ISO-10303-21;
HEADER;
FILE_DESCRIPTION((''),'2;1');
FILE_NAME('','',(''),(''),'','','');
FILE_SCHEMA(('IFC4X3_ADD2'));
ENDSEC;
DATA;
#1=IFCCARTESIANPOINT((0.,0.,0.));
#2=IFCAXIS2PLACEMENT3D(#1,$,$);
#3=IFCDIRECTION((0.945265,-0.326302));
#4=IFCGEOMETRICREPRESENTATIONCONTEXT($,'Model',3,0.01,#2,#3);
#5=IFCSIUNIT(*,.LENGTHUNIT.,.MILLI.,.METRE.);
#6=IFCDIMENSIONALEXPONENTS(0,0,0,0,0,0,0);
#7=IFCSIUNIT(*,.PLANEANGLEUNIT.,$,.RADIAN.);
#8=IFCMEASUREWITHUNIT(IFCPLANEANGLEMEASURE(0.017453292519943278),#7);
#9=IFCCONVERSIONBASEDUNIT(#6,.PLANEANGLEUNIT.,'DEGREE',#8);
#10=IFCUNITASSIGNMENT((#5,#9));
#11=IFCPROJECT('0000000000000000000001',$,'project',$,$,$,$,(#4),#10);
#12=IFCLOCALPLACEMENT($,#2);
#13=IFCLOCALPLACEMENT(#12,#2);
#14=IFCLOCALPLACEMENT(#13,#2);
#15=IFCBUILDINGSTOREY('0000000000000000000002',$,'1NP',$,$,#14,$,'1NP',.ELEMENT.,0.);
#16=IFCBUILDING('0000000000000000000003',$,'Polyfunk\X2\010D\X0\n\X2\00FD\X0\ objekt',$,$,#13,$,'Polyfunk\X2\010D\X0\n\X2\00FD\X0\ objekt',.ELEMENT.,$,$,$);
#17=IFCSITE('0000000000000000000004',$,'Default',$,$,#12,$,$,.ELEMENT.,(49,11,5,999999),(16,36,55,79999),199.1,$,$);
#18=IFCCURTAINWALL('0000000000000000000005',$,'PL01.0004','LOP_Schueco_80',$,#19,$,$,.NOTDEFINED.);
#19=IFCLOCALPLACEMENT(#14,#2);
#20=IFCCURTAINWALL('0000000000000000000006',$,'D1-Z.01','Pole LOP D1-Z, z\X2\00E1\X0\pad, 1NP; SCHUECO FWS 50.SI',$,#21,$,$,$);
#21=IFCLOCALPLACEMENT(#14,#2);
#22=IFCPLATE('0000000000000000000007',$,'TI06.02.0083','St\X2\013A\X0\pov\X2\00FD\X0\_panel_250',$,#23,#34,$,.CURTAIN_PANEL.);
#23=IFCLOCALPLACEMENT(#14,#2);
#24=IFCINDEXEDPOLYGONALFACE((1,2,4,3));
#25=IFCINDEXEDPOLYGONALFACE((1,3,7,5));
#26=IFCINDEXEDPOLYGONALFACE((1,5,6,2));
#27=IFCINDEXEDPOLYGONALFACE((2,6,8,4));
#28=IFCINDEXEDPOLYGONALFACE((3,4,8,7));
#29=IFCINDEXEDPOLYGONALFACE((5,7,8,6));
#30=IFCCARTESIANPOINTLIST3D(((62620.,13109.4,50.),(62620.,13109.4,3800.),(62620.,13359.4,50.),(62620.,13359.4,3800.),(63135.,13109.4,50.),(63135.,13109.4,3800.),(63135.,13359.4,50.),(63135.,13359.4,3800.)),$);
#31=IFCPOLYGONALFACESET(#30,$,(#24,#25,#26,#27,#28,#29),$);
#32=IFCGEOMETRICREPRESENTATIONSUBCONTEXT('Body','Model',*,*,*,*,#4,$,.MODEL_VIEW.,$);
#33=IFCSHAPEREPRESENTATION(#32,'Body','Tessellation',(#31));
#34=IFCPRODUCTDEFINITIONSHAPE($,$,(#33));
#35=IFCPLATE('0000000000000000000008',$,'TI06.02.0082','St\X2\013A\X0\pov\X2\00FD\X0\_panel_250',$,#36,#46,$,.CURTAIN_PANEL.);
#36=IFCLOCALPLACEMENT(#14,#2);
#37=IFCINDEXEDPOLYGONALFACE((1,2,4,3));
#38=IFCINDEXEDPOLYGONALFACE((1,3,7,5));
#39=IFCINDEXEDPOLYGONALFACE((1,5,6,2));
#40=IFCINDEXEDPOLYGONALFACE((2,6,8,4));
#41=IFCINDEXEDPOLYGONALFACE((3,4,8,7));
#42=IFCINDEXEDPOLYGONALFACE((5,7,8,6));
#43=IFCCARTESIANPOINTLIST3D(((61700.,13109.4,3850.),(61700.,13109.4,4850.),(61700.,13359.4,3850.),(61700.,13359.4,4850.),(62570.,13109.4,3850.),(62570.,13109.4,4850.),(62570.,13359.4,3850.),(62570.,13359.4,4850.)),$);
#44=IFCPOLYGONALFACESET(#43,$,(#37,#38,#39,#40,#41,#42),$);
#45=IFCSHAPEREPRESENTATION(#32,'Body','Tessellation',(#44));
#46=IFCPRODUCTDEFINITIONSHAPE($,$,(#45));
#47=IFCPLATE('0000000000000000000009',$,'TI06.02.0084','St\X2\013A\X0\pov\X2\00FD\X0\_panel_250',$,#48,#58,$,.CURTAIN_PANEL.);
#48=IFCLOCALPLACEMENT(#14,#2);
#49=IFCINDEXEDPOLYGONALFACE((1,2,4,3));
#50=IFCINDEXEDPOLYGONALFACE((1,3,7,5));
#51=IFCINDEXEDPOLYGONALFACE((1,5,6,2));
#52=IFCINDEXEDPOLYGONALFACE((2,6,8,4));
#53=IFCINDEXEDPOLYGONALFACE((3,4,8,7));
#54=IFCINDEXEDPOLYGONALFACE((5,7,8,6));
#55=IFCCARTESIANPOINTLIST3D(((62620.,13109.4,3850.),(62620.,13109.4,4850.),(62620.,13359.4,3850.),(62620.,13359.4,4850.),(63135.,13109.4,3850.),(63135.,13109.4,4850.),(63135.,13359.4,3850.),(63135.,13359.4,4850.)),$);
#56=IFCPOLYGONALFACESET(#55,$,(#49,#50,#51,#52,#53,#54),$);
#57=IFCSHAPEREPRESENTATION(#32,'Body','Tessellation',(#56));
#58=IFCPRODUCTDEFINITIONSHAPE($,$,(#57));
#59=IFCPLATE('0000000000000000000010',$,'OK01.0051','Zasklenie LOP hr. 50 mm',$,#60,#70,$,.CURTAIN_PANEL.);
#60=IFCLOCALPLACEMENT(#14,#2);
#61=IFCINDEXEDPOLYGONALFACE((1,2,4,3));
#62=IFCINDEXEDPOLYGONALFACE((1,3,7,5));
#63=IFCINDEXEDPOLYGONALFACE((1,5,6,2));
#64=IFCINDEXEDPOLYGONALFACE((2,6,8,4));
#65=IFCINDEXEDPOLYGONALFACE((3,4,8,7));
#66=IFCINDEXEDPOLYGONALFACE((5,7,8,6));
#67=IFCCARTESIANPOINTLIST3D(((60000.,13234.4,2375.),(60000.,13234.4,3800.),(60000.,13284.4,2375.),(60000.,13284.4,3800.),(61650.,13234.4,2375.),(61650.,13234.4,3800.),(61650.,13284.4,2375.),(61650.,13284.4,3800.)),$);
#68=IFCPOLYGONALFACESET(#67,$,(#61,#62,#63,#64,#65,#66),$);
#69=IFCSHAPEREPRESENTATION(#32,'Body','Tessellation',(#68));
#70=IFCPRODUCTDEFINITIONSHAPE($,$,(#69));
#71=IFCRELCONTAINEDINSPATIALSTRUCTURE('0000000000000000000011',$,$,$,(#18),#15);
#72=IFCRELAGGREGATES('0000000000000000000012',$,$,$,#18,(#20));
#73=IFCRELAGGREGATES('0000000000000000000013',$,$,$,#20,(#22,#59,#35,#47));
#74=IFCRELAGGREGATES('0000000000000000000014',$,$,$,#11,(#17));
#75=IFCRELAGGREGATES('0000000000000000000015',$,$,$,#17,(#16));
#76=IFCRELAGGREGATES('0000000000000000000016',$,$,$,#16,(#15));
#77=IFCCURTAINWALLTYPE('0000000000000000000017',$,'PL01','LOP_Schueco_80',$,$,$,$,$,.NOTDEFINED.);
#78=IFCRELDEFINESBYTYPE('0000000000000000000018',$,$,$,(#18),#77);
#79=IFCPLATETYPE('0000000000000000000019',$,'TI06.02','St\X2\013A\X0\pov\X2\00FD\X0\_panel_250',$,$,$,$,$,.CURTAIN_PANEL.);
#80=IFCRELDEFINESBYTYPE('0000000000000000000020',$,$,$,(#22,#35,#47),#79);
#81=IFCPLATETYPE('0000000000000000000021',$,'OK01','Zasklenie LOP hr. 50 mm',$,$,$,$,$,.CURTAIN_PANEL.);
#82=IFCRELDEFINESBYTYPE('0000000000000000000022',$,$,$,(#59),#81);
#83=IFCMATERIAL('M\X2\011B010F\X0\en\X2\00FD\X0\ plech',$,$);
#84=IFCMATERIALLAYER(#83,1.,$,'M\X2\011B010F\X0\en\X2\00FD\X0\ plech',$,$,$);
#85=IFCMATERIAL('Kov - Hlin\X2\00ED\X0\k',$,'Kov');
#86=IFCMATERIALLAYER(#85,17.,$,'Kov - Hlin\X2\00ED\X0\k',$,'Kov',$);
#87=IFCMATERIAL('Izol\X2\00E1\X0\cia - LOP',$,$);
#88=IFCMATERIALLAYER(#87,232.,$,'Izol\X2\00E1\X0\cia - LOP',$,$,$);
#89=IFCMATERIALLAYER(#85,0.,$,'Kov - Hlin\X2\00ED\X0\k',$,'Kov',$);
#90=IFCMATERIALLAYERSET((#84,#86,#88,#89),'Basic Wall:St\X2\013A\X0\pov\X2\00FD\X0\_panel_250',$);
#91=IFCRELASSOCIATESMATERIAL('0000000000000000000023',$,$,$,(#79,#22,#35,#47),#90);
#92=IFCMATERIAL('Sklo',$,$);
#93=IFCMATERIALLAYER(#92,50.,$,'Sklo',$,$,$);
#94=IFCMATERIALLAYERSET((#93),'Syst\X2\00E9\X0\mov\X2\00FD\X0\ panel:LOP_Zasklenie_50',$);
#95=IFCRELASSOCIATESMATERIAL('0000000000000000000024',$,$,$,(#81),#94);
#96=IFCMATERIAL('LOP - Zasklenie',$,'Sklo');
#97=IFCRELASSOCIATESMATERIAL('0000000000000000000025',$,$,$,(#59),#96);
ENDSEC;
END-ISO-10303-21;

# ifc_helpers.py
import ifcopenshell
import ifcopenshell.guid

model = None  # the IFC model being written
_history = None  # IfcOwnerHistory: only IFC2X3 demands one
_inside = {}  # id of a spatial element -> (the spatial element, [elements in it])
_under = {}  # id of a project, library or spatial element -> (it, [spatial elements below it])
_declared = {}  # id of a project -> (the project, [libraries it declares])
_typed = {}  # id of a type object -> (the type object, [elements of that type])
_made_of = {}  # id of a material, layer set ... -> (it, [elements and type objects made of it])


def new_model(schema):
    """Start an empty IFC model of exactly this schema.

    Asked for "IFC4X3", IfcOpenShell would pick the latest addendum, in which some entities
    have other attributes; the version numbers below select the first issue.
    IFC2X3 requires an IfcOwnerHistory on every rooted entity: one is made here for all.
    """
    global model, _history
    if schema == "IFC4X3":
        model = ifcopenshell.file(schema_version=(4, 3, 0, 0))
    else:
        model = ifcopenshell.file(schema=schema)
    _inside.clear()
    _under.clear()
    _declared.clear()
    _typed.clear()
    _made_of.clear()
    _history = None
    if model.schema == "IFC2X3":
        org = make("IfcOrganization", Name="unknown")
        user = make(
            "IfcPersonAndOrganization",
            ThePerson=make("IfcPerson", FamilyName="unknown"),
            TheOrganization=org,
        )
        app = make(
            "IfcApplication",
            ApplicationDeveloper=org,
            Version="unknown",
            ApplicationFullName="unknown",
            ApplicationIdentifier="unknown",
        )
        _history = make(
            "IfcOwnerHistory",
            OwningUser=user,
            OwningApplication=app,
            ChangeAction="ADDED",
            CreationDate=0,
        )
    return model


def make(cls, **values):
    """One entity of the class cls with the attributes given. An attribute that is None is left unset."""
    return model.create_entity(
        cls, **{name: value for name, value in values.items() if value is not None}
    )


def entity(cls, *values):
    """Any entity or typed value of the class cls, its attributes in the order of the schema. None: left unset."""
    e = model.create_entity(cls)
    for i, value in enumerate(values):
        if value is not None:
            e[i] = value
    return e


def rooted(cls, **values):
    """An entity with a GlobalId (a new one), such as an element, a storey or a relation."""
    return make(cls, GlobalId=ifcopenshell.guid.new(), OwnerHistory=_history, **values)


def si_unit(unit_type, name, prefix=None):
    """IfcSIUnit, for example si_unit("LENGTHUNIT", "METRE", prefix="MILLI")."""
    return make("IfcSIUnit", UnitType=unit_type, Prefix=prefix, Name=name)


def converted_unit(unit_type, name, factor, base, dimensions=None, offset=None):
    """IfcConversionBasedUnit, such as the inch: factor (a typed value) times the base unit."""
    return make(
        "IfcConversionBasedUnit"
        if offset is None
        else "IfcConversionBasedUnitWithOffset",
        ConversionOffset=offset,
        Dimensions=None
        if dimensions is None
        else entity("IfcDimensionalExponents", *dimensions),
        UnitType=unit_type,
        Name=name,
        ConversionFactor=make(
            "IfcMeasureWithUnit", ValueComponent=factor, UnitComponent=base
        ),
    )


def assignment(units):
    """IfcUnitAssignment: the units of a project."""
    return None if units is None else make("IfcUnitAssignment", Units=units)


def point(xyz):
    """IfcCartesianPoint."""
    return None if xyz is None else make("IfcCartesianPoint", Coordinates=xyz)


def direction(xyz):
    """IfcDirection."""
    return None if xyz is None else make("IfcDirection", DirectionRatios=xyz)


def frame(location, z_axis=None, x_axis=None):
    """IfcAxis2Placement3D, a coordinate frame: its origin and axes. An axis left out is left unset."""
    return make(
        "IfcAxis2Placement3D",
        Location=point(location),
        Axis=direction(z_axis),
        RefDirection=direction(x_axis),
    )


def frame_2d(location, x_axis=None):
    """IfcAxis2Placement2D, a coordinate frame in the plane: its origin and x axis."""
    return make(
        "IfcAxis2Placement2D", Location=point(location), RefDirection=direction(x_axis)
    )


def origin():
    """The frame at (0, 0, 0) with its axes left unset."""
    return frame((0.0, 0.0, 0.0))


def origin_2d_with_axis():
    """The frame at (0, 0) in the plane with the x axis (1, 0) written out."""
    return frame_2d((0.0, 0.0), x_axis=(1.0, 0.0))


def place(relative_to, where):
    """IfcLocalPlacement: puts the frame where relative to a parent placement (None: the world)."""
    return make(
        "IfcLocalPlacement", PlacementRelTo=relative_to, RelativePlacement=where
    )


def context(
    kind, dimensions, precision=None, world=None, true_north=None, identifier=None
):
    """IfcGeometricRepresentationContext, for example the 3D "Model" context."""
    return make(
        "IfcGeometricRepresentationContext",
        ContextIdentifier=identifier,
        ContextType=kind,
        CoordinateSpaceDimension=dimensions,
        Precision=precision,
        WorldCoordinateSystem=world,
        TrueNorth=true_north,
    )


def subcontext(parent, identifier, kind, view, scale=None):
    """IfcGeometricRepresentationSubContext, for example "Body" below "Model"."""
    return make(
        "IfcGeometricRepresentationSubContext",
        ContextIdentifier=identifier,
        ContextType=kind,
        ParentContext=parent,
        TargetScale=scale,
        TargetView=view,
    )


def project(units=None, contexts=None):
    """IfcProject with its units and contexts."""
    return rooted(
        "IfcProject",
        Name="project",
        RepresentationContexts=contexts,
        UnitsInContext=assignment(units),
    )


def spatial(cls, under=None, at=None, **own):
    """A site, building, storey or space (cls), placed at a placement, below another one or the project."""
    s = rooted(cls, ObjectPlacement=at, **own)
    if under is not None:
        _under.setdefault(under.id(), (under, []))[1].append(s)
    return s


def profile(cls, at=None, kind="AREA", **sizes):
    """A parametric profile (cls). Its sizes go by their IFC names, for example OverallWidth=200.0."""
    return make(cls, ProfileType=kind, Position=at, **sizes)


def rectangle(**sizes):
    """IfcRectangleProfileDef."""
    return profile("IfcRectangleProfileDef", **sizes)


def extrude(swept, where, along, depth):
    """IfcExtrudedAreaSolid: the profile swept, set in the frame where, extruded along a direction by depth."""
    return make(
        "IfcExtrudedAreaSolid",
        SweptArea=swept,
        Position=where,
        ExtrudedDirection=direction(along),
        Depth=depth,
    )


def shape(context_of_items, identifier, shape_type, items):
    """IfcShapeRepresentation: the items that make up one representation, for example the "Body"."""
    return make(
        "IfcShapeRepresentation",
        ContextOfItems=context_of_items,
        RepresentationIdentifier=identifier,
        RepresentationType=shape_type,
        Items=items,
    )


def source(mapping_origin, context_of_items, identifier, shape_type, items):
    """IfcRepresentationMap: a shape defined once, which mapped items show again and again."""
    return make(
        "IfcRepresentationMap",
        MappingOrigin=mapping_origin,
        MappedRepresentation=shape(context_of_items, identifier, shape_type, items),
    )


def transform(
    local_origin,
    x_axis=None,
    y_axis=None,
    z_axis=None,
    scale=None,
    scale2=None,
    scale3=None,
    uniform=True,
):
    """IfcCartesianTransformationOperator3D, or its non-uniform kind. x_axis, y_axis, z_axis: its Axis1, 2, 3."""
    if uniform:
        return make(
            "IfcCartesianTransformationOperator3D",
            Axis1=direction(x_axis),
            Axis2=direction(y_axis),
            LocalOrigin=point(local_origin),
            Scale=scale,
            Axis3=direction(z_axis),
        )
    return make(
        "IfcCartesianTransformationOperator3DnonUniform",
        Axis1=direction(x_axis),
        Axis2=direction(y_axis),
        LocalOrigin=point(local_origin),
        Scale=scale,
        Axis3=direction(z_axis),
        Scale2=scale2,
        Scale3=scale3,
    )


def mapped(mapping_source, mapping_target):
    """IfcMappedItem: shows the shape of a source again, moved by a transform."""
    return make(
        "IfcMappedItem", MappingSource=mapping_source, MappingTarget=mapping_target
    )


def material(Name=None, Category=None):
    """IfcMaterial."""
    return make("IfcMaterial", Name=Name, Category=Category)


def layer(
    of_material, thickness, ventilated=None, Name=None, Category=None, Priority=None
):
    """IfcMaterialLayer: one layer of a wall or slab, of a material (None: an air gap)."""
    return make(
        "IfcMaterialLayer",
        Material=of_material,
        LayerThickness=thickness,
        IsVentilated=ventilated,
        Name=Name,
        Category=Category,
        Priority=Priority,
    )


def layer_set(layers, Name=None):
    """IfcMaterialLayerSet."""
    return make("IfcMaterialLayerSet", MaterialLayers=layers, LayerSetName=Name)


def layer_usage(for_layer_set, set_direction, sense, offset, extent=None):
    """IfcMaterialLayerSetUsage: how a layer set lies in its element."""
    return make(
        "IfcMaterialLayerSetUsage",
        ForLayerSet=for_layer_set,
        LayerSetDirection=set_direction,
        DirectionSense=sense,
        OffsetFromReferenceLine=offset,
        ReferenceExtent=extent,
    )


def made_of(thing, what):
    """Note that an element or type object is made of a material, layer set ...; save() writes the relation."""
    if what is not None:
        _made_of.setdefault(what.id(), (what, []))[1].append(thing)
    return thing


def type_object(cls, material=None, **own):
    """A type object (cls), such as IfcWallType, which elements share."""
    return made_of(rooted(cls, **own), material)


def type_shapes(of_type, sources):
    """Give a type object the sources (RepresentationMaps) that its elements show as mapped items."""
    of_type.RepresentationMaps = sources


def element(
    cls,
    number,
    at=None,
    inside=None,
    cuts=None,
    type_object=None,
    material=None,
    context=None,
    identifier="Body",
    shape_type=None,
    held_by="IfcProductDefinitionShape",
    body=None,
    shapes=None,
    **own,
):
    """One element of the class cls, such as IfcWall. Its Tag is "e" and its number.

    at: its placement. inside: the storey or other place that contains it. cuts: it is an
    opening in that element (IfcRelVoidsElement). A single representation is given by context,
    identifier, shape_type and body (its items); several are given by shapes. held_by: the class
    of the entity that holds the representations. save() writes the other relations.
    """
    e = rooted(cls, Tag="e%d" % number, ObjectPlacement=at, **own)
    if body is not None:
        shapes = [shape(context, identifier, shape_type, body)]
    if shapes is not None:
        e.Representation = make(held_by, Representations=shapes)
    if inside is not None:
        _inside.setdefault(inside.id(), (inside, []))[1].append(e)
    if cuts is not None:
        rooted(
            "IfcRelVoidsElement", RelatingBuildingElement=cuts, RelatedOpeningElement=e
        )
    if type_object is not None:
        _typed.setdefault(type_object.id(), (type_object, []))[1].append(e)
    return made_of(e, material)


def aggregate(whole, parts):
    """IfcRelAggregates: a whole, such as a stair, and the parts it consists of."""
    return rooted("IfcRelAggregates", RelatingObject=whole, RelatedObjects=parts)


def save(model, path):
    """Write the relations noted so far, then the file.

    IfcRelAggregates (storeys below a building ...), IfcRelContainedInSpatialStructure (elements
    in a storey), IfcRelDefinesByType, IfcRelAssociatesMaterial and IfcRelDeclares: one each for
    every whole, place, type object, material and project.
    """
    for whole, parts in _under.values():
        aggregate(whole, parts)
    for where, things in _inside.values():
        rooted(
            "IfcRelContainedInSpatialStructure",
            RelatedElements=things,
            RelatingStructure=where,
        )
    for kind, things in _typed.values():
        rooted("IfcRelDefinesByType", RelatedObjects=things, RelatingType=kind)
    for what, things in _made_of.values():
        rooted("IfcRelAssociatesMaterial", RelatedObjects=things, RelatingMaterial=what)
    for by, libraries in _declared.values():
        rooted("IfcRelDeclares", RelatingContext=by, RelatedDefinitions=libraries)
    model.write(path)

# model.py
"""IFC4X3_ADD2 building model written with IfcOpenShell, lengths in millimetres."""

from ifc_helpers import new_model, entity, si_unit, converted_unit, direction, frame, frame_2d, origin, origin_2d_with_axis, place, context, subcontext, project, spatial, rectangle, extrude, source, transform, mapped, material, layer, layer_set, layer_usage, type_object, type_shapes, element, aggregate, save


model = new_model("IFC4X3_ADD2")

# Units and contexts
model_context = context("Model", 3, precision=0.01, world=origin(), true_north=direction((0.945265, -0.326302)))
body_context = subcontext(model_context, "Body", "Model", "MODEL_VIEW")
ifc_project = project(units=[si_unit("LENGTHUNIT", "METRE", prefix="MILLI"), converted_unit("PLANEANGLEUNIT", "DEGREE", entity("IfcPlaneAngleMeasure", 0.017453292519943278), si_unit("PLANEANGLEUNIT", "RADIAN"), dimensions=[0, 0, 0, 0, 0, 0, 0])], contexts=[model_context])

# Site, building, storey
site_placement = place(None, origin())
site = spatial("IfcSite", under=ifc_project, at=site_placement, Name="Default", CompositionType="ELEMENT", RefLatitude=(49, 11, 5, 999999), RefLongitude=(16, 36, 55, 79999), RefElevation=199.1)
building_placement = place(site_placement, origin())
building = spatial("IfcBuilding", under=site, at=building_placement, Name="Polyfunkčný objekt", LongName="Polyfunkčný objekt", CompositionType="ELEMENT")
storey_placement = place(building_placement, origin())
storey = spatial("IfcBuildingStorey", under=building, at=storey_placement, Name="1NP", LongName="1NP", CompositionType="ELEMENT", Elevation=0.0)

# Curtain walls, plates
curtain_wall_type = type_object("IfcCurtainWallType", Name="PL01", Description="LOP_Schueco_80", PredefinedType="NOTDEFINED")
curtain_wall_1_placement = place(storey_placement, origin())
curtain_wall_1 = element("IfcCurtainWall", 1, at=curtain_wall_1_placement, inside=storey, type_object=curtain_wall_type, Name="PL01.0004", Description="LOP_Schueco_80", PredefinedType="NOTDEFINED")
curtain_wall_2 = element("IfcCurtainWall", 2, Name="D1-Z.01", Description="Pole LOP D1-Z, západ, 1NP; SCHUECO FWS 50.SI")
aggregate(curtain_wall_1, [curtain_wall_2])
ifc_material_1 = material(Name="Měďený plech")
ifc_layer_1 = layer(ifc_material_1, 1.0, Name="Měďený plech")
ifc_material_2 = material(Name="Kov - Hliník", Category="Kov")
ifc_layer_2 = layer(ifc_material_2, 17.0, Name="Kov - Hliník", Category="Kov")
ifc_material_3 = material(Name="Izolácia - LOP")
ifc_layer_3 = layer(ifc_material_3, 232.0, Name="Izolácia - LOP")
ifc_layer_4 = layer(ifc_material_2, 0.0, Name="Kov - Hliník", Category="Kov")
ifc_layer_set_1 = layer_set([ifc_layer_1, ifc_layer_2, ifc_layer_3, ifc_layer_4], Name="Basic Wall:Stĺpový_panel_250")
ifc_layer_usage_1 = layer_usage(ifc_layer_set_1, "AXIS2", "NEGATIVE", 125.0)
plate_type_1 = type_object("IfcPlateType", Name="TI06.02", Description="Stĺpový_panel_250", PredefinedType="CURTAIN_PANEL", material=ifc_layer_set_1)
plate_1_placement = place(storey_placement, frame((62620.0, 13234.4, 50.0)))
plate_1 = element("IfcPlate", 3, at=plate_1_placement, type_object=plate_type_1, material=ifc_layer_usage_1, Name="TI06.02.0083", Description="Stĺpový_panel_250", PredefinedType="CURTAIN_PANEL", context=body_context, shape_type="SweptSolid", body=[
    extrude(rectangle(XDim=250.0, YDim=515.0, at=frame_2d((0.0, 0.0), x_axis=(1.0, 0.0))), frame((257.5, 0.0, 0.0), z_axis=(0.0, 0.0, 1.0), x_axis=(0.0, 1.0, 0.0)), (0.0, 0.0, 1.0), 3750.0),
])
ifc_layer_usage_2 = layer_usage(ifc_layer_set_1, "AXIS2", "NEGATIVE", 125.0)
plate_2_placement = place(storey_placement, frame((61700.0, 13234.4, 3850.0)))
plate_2 = element("IfcPlate", 4, at=plate_2_placement, type_object=plate_type_1, material=ifc_layer_usage_2, Name="TI06.02.0082", Description="Stĺpový_panel_250", PredefinedType="CURTAIN_PANEL", context=body_context, shape_type="SweptSolid", body=[
    extrude(rectangle(XDim=250.0, YDim=870.0, at=frame_2d((0.0, 0.0), x_axis=(1.0, 0.0))), frame((435.0, 0.0, 0.0), z_axis=(0.0, 0.0, 1.0), x_axis=(0.0, 1.0, 0.0)), (0.0, 0.0, 1.0), 1000.0),
])
ifc_layer_usage_3 = layer_usage(ifc_layer_set_1, "AXIS2", "NEGATIVE", 125.0)
plate_3_placement = place(storey_placement, frame((62620.0, 13234.4, 3850.0)))
plate_3 = element("IfcPlate", 5, at=plate_3_placement, type_object=plate_type_1, material=ifc_layer_usage_3, Name="TI06.02.0084", Description="Stĺpový_panel_250", PredefinedType="CURTAIN_PANEL", context=body_context, shape_type="SweptSolid", body=[
    extrude(rectangle(XDim=250.0, YDim=515.0, at=frame_2d((0.0, 0.0), x_axis=(1.0, 0.0))), frame((257.5, 0.0, 0.0), z_axis=(0.0, 0.0, 1.0), x_axis=(0.0, 1.0, 0.0)), (0.0, 0.0, 1.0), 1000.0),
])

# Plate
ifc_material_4 = material(Name="LOP - Zasklenie", Category="Sklo")
ifc_material_5 = material(Name="Sklo")
ifc_layer_5 = layer(ifc_material_5, 50.0, Name="Sklo")
ifc_layer_set_2 = layer_set([ifc_layer_5], Name="Systémový panel:LOP_Zasklenie_50")
plate_type_2 = type_object("IfcPlateType", Name="OK01", Description="Zasklenie LOP hr. 50 mm", PredefinedType="CURTAIN_PANEL", material=ifc_layer_set_2)
shared_shape_1 = source(origin(), body_context, "Body", "SweptSolid", [
    extrude(rectangle(XDim=50.0, YDim=1650.0, at=origin_2d_with_axis()), frame((0.0, 25.0, 0.0), z_axis=(0.0, 0.0, 1.0), x_axis=(0.0, 1.0, 0.0)), (0.0, 0.0, 1.0), 1425.0),
])
type_shapes(plate_type_2, [shared_shape_1])
plate_4_placement = place(curtain_wall_1_placement, frame((60825.0, 13234.4, 2375.0)))
plate_4 = element("IfcPlate", 6, at=plate_4_placement, type_object=plate_type_2, material=ifc_material_4, Name="OK01.0051", Description="Zasklenie LOP hr. 50 mm", PredefinedType="CURTAIN_PANEL", context=body_context, shape_type="MappedRepresentation", body=[
    mapped(shared_shape_1, transform((0.0, 0.0, 0.0), scale=1.0)),
])
aggregate(curtain_wall_2, [plate_1, plate_4, plate_2, plate_3])

save(model, "model.ifc")
